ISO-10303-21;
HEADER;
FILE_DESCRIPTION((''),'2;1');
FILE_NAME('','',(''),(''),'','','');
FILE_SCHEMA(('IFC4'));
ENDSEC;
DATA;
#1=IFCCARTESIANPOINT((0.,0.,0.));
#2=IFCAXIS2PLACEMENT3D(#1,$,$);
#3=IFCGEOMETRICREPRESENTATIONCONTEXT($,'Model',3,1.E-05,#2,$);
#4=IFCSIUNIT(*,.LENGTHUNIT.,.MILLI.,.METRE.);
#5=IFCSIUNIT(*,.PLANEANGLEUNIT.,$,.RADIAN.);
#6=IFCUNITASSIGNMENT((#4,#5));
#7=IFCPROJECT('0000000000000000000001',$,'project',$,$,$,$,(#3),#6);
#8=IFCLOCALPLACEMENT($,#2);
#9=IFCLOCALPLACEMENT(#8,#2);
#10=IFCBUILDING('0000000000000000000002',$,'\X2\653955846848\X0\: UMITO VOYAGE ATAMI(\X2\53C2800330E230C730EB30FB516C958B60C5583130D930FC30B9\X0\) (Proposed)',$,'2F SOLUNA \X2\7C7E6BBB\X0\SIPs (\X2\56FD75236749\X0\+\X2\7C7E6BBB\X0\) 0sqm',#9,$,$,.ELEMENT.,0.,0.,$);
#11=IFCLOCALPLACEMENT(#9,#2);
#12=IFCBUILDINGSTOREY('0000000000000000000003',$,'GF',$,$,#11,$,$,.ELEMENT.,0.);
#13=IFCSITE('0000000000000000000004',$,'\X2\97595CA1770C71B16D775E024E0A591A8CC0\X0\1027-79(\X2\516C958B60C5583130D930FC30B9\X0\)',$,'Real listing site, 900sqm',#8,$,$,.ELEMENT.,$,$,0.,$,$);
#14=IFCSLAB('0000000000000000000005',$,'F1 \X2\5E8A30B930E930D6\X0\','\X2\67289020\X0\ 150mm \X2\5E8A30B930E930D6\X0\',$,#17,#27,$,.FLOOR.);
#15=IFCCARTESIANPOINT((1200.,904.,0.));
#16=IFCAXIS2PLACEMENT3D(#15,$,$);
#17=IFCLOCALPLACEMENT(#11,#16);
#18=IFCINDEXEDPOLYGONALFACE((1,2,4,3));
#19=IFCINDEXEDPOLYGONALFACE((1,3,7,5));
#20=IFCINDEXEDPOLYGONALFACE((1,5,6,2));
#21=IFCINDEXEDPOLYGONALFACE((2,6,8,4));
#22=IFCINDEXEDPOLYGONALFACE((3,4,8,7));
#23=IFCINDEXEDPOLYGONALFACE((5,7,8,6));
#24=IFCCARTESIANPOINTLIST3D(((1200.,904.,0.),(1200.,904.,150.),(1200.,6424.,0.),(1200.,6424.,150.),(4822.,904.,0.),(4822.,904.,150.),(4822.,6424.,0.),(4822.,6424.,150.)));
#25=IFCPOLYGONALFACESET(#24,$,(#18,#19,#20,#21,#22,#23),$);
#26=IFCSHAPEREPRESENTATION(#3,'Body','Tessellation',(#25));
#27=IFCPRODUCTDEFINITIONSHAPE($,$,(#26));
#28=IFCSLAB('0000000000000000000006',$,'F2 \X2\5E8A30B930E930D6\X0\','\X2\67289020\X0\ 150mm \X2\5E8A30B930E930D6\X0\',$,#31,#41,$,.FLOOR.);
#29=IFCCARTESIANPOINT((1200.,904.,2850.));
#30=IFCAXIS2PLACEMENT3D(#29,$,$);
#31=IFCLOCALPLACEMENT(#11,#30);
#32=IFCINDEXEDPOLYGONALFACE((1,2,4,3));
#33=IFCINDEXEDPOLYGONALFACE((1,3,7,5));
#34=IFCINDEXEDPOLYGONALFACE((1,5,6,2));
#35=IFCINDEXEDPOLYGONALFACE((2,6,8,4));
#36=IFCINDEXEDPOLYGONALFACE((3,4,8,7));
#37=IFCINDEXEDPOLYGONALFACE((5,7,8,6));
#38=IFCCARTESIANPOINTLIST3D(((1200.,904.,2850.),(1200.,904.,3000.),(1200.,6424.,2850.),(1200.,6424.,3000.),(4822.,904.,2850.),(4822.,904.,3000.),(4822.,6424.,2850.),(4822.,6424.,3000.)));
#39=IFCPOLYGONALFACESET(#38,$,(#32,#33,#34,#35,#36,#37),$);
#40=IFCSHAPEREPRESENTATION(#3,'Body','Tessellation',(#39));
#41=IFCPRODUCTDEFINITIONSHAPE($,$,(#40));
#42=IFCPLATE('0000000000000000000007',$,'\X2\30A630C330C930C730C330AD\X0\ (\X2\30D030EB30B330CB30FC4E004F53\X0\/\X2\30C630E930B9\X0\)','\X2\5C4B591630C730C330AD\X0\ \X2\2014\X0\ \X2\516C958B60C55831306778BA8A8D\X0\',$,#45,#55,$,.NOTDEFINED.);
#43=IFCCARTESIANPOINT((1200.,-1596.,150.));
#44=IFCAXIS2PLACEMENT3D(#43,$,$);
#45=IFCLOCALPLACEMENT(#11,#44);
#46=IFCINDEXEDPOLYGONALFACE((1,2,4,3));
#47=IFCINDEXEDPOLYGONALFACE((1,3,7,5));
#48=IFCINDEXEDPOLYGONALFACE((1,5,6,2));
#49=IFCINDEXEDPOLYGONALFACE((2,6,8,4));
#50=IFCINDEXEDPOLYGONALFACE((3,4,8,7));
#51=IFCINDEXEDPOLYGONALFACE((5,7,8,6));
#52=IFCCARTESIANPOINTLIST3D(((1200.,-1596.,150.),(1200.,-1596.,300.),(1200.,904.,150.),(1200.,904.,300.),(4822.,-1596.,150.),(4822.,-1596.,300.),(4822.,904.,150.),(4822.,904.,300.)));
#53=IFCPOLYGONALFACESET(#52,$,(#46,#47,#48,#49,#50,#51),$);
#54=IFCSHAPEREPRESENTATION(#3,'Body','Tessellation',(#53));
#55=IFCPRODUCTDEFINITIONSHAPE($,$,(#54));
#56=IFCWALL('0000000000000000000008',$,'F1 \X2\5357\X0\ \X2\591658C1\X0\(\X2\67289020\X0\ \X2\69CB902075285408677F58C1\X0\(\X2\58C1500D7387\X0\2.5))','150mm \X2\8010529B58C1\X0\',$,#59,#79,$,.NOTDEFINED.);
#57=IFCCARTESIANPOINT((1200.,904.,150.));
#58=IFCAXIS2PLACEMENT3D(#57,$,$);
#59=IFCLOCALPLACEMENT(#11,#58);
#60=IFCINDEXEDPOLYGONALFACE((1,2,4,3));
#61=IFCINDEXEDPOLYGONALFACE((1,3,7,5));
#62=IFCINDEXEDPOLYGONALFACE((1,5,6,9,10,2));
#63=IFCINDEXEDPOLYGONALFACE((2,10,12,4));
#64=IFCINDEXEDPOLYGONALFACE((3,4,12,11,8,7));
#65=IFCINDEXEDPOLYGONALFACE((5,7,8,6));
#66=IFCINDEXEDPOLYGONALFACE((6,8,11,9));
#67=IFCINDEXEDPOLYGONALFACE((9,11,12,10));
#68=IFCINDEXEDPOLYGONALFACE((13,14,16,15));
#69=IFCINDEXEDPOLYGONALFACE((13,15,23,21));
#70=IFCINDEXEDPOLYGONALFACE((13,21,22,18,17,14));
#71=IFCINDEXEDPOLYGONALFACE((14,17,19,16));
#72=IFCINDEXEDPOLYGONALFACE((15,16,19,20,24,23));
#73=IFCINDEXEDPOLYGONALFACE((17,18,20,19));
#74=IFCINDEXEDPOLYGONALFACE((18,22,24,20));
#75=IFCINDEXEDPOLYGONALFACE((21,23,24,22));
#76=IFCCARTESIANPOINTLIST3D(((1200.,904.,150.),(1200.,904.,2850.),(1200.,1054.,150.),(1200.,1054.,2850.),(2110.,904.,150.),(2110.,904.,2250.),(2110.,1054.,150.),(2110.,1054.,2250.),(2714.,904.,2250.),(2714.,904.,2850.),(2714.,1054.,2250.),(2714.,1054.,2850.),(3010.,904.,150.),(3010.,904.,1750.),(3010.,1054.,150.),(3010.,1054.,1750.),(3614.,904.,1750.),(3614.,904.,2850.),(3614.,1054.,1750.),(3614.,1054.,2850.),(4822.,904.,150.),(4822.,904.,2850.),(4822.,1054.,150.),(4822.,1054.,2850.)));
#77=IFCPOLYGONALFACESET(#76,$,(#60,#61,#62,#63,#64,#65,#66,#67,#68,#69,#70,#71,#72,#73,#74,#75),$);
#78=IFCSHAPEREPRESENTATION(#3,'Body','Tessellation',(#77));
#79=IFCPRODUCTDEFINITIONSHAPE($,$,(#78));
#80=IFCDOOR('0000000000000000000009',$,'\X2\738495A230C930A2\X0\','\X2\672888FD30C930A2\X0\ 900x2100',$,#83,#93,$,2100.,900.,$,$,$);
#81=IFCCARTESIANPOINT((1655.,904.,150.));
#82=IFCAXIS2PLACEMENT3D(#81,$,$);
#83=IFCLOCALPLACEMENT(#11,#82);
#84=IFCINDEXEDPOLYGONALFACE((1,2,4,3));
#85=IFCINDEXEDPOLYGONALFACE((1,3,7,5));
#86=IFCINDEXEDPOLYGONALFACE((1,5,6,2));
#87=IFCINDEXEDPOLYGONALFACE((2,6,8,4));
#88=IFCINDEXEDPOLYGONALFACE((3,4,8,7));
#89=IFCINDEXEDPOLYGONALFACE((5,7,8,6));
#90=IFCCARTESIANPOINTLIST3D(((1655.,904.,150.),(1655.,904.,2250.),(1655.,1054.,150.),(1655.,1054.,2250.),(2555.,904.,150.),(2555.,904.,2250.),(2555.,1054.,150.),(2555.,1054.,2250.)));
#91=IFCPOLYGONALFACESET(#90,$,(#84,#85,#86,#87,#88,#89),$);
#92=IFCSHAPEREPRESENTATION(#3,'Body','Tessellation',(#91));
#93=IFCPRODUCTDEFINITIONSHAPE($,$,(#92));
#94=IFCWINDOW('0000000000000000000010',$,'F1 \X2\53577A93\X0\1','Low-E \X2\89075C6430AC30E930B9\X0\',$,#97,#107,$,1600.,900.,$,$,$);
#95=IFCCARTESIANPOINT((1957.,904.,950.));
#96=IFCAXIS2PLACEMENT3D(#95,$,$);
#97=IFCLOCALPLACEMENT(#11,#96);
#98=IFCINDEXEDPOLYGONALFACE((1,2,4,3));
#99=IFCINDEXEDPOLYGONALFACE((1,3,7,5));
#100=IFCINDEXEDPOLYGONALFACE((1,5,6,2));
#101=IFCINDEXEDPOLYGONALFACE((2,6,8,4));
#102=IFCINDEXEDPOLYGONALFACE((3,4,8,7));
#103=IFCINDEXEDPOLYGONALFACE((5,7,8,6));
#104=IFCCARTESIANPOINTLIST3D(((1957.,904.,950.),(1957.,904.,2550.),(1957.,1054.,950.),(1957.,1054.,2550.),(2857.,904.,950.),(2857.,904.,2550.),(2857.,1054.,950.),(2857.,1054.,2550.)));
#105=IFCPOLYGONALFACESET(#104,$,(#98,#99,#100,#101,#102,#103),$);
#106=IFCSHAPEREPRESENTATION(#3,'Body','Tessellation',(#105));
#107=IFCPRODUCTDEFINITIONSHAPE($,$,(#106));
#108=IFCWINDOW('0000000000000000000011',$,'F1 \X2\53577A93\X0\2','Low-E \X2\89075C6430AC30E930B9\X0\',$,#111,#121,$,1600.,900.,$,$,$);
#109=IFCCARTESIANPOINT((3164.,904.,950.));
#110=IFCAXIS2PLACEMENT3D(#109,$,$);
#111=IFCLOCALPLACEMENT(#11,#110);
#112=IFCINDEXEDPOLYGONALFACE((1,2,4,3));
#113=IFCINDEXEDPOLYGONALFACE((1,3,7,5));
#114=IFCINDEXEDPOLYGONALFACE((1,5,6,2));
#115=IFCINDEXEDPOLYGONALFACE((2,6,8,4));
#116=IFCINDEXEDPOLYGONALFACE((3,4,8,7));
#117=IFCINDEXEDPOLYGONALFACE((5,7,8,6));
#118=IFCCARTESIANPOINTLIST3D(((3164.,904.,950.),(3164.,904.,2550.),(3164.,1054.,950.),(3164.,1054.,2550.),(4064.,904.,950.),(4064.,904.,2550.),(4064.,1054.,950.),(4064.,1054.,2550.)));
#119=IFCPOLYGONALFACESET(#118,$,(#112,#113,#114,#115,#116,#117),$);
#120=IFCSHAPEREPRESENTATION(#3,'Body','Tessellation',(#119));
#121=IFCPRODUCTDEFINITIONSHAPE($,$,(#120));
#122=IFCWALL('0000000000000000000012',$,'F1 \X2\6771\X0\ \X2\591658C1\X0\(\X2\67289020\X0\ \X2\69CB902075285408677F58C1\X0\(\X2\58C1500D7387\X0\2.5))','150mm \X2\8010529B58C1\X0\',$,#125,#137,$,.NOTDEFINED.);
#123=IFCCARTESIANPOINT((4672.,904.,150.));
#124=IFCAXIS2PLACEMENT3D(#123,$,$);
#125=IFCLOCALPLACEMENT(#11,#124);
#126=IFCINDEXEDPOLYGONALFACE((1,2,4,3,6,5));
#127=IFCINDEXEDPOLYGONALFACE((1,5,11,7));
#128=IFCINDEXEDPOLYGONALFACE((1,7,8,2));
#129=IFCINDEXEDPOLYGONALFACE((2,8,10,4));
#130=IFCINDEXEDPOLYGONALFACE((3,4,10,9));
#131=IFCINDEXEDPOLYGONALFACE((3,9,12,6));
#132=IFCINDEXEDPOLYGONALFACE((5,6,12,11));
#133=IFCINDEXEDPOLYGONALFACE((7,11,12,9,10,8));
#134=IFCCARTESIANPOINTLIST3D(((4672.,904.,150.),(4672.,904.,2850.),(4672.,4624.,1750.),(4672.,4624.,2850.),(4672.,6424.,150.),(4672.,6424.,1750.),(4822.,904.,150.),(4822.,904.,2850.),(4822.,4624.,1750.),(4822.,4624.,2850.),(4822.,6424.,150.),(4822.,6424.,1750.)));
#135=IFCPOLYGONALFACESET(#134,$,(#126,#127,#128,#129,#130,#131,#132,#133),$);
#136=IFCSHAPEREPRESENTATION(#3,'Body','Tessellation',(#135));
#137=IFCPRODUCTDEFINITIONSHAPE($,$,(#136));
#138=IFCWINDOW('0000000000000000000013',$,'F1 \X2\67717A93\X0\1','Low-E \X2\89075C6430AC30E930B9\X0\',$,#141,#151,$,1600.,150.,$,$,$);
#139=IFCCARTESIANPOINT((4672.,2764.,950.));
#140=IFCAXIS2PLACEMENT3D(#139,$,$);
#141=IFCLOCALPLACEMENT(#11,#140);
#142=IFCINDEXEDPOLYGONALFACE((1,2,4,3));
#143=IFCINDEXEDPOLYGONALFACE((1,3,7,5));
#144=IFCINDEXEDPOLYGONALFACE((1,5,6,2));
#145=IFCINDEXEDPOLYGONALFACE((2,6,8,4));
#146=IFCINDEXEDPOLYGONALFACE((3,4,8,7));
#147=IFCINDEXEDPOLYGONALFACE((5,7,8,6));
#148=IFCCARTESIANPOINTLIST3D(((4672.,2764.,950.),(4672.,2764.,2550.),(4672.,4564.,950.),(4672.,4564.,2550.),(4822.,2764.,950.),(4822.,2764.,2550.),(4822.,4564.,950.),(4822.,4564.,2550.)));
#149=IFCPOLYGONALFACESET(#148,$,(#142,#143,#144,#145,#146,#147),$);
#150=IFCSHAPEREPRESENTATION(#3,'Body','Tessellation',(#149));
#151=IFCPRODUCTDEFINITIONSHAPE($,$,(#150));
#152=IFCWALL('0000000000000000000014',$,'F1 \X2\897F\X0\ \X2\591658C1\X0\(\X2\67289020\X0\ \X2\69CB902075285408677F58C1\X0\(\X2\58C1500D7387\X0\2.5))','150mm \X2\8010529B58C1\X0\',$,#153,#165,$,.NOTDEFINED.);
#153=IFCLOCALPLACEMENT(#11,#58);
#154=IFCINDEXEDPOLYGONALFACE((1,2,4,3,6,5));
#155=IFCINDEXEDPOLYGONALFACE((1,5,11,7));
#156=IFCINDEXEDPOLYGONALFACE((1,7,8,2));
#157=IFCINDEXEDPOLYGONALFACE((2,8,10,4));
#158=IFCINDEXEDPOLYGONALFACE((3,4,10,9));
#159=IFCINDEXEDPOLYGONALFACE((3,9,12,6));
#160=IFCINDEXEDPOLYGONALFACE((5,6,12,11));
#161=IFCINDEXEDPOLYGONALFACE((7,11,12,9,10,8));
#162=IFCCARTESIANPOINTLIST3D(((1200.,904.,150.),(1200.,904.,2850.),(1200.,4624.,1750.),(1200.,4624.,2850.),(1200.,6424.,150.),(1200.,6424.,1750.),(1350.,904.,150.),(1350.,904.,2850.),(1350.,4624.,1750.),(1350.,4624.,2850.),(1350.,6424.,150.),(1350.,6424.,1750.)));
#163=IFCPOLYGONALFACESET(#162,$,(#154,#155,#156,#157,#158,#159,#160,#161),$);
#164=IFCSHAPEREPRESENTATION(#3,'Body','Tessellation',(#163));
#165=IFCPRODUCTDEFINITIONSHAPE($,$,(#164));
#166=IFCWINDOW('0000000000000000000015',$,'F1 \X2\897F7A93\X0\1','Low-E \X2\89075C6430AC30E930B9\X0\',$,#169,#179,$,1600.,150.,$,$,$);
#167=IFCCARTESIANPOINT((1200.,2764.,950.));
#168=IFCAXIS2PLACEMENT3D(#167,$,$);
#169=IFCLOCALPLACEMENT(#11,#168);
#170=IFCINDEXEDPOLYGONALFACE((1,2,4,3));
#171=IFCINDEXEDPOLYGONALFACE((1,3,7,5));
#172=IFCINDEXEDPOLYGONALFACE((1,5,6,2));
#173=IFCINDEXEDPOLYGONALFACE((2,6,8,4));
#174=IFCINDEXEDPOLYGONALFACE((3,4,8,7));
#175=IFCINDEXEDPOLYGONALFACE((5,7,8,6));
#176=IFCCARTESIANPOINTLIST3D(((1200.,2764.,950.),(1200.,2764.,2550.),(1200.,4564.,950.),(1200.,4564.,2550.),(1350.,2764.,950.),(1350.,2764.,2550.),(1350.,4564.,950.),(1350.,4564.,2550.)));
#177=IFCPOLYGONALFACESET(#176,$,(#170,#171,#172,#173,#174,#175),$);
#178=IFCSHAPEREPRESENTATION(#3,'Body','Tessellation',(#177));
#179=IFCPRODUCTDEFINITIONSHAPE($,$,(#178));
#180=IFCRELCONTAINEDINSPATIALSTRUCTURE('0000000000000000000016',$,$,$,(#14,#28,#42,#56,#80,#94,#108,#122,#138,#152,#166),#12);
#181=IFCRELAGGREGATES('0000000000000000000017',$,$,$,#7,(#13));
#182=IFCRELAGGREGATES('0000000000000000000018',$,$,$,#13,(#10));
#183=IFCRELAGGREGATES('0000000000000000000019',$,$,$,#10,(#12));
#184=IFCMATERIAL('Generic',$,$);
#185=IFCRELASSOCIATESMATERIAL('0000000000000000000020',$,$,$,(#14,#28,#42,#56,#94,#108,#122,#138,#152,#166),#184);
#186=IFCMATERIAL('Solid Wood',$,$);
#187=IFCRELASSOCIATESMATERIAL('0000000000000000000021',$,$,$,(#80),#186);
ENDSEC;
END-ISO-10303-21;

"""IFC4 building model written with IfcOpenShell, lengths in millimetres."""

from ifc_helpers import new_model, si_unit, frame, frame_2d, origin, place, context, project, spatial, rectangle, extrude, material, element, fill, save


model = new_model("IFC4")

# Units and contexts
model_context = context("Model", 3, precision=1e-05, world=origin())
ifc_project = project(units=[si_unit("LENGTHUNIT", "METRE", prefix="MILLI"), si_unit("PLANEANGLEUNIT", "RADIAN")], contexts=[model_context])

# Site, building, storey
site_placement = place(None, origin())
site = spatial("IfcSite", under=ifc_project, at=site_placement, Name="静岡県熱海市上多賀1027-79(公開情報ベース)", ObjectType="Real listing site, 900sqm", CompositionType="ELEMENT", RefElevation=0.0)
building_placement = place(site_placement, origin())
building = spatial("IfcBuilding", under=site, at=building_placement, Name="改善案: UMITO VOYAGE ATAMI(参考モデル・公開情報ベース) (Proposed)", ObjectType="2F SOLUNA 籾殻SIPs (国産杉+籾殻) 0sqm", CompositionType="ELEMENT", ElevationOfRefHeight=0.0, ElevationOfTerrain=0.0)
storey_placement = place(building_placement, origin())
storey = spatial("IfcBuildingStorey", under=building, at=storey_placement, Name="GF", CompositionType="ELEMENT", Elevation=0.0)

# Slabs
ifc_material_1 = material(Name="Generic")
slab_1_placement = place(storey_placement, frame((1200.0, 904.0, 0.0)))
element("IfcSlab", 1, at=slab_1_placement, inside=storey, material=ifc_material_1, Name="F1 床スラブ", Description="木造 150mm 床スラブ", PredefinedType="FLOOR", context=model_context, shape_type="SweptSolid", body=[
    extrude(rectangle(XDim=3622.0, YDim=5520.0, at=frame_2d((1811.0, 2760.0))), frame((1200.0, 904.0, 0.0)), (0.0, 0.0, 1.0), 150.0),
])
slab_2_placement = place(storey_placement, frame((1200.0, 904.0, 2850.0)))
element("IfcSlab", 2, at=slab_2_placement, inside=storey, material=ifc_material_1, Name="F2 床スラブ", Description="木造 150mm 床スラブ", PredefinedType="FLOOR", context=model_context, shape_type="SweptSolid", body=[
    extrude(rectangle(XDim=3622.0, YDim=5520.0, at=frame_2d((1811.0, 2760.0))), frame((1200.0, 904.0, 2850.0)), (0.0, 0.0, 1.0), 150.0),
])

# Plate
plate_placement = place(storey_placement, frame((1200.0, -1596.0, 150.0)))
element("IfcPlate", 3, at=plate_placement, inside=storey, material=ifc_material_1, Name="ウッドデッキ (バルコニー一体/テラス)", Description="屋外デッキ — 公開情報で確認", PredefinedType="NOTDEFINED", context=model_context, shape_type="SweptSolid", body=[
    extrude(rectangle(XDim=3622.0, YDim=2500.0, at=frame_2d((1811.0, 1250.0))), frame((1200.0, -1596.0, 150.0)), (0.0, 0.0, 1.0), 150.0),
])

# Wall, openings, door, windows
wall_1_placement = place(storey_placement, frame((1200.0, 904.0, 150.0)))
wall_1 = element("IfcWall", 4, at=wall_1_placement, inside=storey, material=ifc_material_1, Name="F1 南 外壁(木造 構造用合板壁(壁倍率2.5))", Description="150mm 耐力壁", PredefinedType="NOTDEFINED", context=model_context, shape_type="SweptSolid", body=[
    extrude(rectangle(XDim=3622.0, YDim=150.0, at=frame_2d((1811.0, 75.0))), frame((1200.0, 904.0, 150.0)), (0.0, 0.0, 1.0), 2700.0),
])
opening_1_placement = place(storey_placement, frame((1655.0, 904.0, 150.0)))
opening_1 = element("IfcOpeningElement", 5, at=opening_1_placement, cuts=wall_1, PredefinedType="NOTDEFINED", context=model_context, shape_type="SweptSolid", body=[
    extrude(rectangle(XDim=900.0, YDim=150.0, at=frame_2d((450.0, 75.0))), frame((1655.0, 904.0, 150.0)), (0.0, 0.0, 1.0), 2100.0),
])
opening_2_placement = place(storey_placement, frame((1957.0, 904.0, 950.0)))
opening_2 = element("IfcOpeningElement", 6, at=opening_2_placement, cuts=wall_1, PredefinedType="NOTDEFINED", context=model_context, shape_type="SweptSolid", body=[
    extrude(rectangle(XDim=900.0, YDim=150.0, at=frame_2d((450.0, 75.0))), frame((1957.0, 904.0, 950.0)), (0.0, 0.0, 1.0), 1600.0),
])
opening_3_placement = place(storey_placement, frame((3164.0, 904.0, 950.0)))
opening_3 = element("IfcOpeningElement", 7, at=opening_3_placement, cuts=wall_1, PredefinedType="NOTDEFINED", context=model_context, shape_type="SweptSolid", body=[
    extrude(rectangle(XDim=900.0, YDim=150.0, at=frame_2d((450.0, 75.0))), frame((3164.0, 904.0, 950.0)), (0.0, 0.0, 1.0), 1600.0),
])
ifc_material_2 = material(Name="Solid Wood")
door_placement = place(storey_placement, frame((1655.0, 904.0, 150.0)))
door = element("IfcDoor", 8, at=door_placement, inside=storey, material=ifc_material_2, Name="玄関ドア", Description="木製ドア 900x2100", OverallHeight=2100.0, OverallWidth=900.0, context=model_context, shape_type="SweptSolid", body=[
    extrude(rectangle(XDim=900.0, YDim=150.0, at=frame_2d((450.0, 75.0))), frame((1655.0, 904.0, 150.0)), (0.0, 0.0, 1.0), 2100.0),
])
fill(opening_1, door)
window_1_placement = place(storey_placement, frame((1957.0, 904.0, 950.0)))
window_1 = element("IfcWindow", 9, at=window_1_placement, inside=storey, material=ifc_material_1, Name="F1 南窓1", Description="Low-E 複層ガラス", OverallHeight=1600.0, OverallWidth=900.0, context=model_context, shape_type="SweptSolid", body=[
    extrude(rectangle(XDim=900.0, YDim=150.0, at=frame_2d((450.0, 75.0))), frame((1957.0, 904.0, 950.0)), (0.0, 0.0, 1.0), 1600.0),
])
fill(opening_2, window_1)
window_2_placement = place(storey_placement, frame((3164.0, 904.0, 950.0)))
window_2 = element("IfcWindow", 10, at=window_2_placement, inside=storey, material=ifc_material_1, Name="F1 南窓2", Description="Low-E 複層ガラス", OverallHeight=1600.0, OverallWidth=900.0, context=model_context, shape_type="SweptSolid", body=[
    extrude(rectangle(XDim=900.0, YDim=150.0, at=frame_2d((450.0, 75.0))), frame((3164.0, 904.0, 950.0)), (0.0, 0.0, 1.0), 1600.0),
])
fill(opening_3, window_2)

# Walls, openings, windows
wall_2_placement = place(storey_placement, frame((4672.0, 904.0, 150.0)))
wall_2 = element("IfcWall", 11, at=wall_2_placement, inside=storey, material=ifc_material_1, Name="F1 東 外壁(木造 構造用合板壁(壁倍率2.5))", Description="150mm 耐力壁", PredefinedType="NOTDEFINED", context=model_context, shape_type="SweptSolid", body=[
    extrude(rectangle(XDim=150.0, YDim=5520.0, at=frame_2d((75.0, 2760.0))), frame((4672.0, 904.0, 150.0)), (0.0, 0.0, 1.0), 2700.0),
])
opening_4_placement = place(storey_placement, frame((4672.0, 2764.0, 950.0)))
opening_4 = element("IfcOpeningElement", 12, at=opening_4_placement, cuts=wall_2, PredefinedType="NOTDEFINED", context=model_context, shape_type="SweptSolid", body=[
    extrude(rectangle(XDim=150.0, YDim=1800.0, at=frame_2d((75.0, 900.0))), frame((4672.0, 2764.0, 950.0)), (0.0, 0.0, 1.0), 1600.0),
])
window_3_placement = place(storey_placement, frame((4672.0, 2764.0, 950.0)))
window_3 = element("IfcWindow", 13, at=window_3_placement, inside=storey, material=ifc_material_1, Name="F1 東窓1", Description="Low-E 複層ガラス", OverallHeight=1600.0, OverallWidth=150.0, context=model_context, shape_type="SweptSolid", body=[
    extrude(rectangle(XDim=150.0, YDim=1800.0, at=frame_2d((75.0, 900.0))), frame((4672.0, 2764.0, 950.0)), (0.0, 0.0, 1.0), 1600.0),
])
fill(opening_4, window_3)
wall_3_placement = place(storey_placement, frame((1200.0, 904.0, 150.0)))
wall_3 = element("IfcWall", 14, at=wall_3_placement, inside=storey, material=ifc_material_1, Name="F1 西 外壁(木造 構造用合板壁(壁倍率2.5))", Description="150mm 耐力壁", PredefinedType="NOTDEFINED", context=model_context, shape_type="SweptSolid", body=[
    extrude(rectangle(XDim=150.0, YDim=5520.0, at=frame_2d((75.0, 2760.0))), frame((1200.0, 904.0, 150.0)), (0.0, 0.0, 1.0), 2700.0),
])
opening_5_placement = place(storey_placement, frame((1200.0, 2764.0, 950.0)))
opening_5 = element("IfcOpeningElement", 15, at=opening_5_placement, cuts=wall_3, PredefinedType="NOTDEFINED", context=model_context, shape_type="SweptSolid", body=[
    extrude(rectangle(XDim=150.0, YDim=1800.0, at=frame_2d((75.0, 900.0))), frame((1200.0, 2764.0, 950.0)), (0.0, 0.0, 1.0), 1600.0),
])
window_4_placement = place(storey_placement, frame((1200.0, 2764.0, 950.0)))
window_4 = element("IfcWindow", 16, at=window_4_placement, inside=storey, material=ifc_material_1, Name="F1 西窓1", Description="Low-E 複層ガラス", OverallHeight=1600.0, OverallWidth=150.0, context=model_context, shape_type="SweptSolid", body=[
    extrude(rectangle(XDim=150.0, YDim=1800.0, at=frame_2d((75.0, 900.0))), frame((1200.0, 2764.0, 950.0)), (0.0, 0.0, 1.0), 1600.0),
])
fill(opening_5, window_4)

save(model, "model.ifc")
